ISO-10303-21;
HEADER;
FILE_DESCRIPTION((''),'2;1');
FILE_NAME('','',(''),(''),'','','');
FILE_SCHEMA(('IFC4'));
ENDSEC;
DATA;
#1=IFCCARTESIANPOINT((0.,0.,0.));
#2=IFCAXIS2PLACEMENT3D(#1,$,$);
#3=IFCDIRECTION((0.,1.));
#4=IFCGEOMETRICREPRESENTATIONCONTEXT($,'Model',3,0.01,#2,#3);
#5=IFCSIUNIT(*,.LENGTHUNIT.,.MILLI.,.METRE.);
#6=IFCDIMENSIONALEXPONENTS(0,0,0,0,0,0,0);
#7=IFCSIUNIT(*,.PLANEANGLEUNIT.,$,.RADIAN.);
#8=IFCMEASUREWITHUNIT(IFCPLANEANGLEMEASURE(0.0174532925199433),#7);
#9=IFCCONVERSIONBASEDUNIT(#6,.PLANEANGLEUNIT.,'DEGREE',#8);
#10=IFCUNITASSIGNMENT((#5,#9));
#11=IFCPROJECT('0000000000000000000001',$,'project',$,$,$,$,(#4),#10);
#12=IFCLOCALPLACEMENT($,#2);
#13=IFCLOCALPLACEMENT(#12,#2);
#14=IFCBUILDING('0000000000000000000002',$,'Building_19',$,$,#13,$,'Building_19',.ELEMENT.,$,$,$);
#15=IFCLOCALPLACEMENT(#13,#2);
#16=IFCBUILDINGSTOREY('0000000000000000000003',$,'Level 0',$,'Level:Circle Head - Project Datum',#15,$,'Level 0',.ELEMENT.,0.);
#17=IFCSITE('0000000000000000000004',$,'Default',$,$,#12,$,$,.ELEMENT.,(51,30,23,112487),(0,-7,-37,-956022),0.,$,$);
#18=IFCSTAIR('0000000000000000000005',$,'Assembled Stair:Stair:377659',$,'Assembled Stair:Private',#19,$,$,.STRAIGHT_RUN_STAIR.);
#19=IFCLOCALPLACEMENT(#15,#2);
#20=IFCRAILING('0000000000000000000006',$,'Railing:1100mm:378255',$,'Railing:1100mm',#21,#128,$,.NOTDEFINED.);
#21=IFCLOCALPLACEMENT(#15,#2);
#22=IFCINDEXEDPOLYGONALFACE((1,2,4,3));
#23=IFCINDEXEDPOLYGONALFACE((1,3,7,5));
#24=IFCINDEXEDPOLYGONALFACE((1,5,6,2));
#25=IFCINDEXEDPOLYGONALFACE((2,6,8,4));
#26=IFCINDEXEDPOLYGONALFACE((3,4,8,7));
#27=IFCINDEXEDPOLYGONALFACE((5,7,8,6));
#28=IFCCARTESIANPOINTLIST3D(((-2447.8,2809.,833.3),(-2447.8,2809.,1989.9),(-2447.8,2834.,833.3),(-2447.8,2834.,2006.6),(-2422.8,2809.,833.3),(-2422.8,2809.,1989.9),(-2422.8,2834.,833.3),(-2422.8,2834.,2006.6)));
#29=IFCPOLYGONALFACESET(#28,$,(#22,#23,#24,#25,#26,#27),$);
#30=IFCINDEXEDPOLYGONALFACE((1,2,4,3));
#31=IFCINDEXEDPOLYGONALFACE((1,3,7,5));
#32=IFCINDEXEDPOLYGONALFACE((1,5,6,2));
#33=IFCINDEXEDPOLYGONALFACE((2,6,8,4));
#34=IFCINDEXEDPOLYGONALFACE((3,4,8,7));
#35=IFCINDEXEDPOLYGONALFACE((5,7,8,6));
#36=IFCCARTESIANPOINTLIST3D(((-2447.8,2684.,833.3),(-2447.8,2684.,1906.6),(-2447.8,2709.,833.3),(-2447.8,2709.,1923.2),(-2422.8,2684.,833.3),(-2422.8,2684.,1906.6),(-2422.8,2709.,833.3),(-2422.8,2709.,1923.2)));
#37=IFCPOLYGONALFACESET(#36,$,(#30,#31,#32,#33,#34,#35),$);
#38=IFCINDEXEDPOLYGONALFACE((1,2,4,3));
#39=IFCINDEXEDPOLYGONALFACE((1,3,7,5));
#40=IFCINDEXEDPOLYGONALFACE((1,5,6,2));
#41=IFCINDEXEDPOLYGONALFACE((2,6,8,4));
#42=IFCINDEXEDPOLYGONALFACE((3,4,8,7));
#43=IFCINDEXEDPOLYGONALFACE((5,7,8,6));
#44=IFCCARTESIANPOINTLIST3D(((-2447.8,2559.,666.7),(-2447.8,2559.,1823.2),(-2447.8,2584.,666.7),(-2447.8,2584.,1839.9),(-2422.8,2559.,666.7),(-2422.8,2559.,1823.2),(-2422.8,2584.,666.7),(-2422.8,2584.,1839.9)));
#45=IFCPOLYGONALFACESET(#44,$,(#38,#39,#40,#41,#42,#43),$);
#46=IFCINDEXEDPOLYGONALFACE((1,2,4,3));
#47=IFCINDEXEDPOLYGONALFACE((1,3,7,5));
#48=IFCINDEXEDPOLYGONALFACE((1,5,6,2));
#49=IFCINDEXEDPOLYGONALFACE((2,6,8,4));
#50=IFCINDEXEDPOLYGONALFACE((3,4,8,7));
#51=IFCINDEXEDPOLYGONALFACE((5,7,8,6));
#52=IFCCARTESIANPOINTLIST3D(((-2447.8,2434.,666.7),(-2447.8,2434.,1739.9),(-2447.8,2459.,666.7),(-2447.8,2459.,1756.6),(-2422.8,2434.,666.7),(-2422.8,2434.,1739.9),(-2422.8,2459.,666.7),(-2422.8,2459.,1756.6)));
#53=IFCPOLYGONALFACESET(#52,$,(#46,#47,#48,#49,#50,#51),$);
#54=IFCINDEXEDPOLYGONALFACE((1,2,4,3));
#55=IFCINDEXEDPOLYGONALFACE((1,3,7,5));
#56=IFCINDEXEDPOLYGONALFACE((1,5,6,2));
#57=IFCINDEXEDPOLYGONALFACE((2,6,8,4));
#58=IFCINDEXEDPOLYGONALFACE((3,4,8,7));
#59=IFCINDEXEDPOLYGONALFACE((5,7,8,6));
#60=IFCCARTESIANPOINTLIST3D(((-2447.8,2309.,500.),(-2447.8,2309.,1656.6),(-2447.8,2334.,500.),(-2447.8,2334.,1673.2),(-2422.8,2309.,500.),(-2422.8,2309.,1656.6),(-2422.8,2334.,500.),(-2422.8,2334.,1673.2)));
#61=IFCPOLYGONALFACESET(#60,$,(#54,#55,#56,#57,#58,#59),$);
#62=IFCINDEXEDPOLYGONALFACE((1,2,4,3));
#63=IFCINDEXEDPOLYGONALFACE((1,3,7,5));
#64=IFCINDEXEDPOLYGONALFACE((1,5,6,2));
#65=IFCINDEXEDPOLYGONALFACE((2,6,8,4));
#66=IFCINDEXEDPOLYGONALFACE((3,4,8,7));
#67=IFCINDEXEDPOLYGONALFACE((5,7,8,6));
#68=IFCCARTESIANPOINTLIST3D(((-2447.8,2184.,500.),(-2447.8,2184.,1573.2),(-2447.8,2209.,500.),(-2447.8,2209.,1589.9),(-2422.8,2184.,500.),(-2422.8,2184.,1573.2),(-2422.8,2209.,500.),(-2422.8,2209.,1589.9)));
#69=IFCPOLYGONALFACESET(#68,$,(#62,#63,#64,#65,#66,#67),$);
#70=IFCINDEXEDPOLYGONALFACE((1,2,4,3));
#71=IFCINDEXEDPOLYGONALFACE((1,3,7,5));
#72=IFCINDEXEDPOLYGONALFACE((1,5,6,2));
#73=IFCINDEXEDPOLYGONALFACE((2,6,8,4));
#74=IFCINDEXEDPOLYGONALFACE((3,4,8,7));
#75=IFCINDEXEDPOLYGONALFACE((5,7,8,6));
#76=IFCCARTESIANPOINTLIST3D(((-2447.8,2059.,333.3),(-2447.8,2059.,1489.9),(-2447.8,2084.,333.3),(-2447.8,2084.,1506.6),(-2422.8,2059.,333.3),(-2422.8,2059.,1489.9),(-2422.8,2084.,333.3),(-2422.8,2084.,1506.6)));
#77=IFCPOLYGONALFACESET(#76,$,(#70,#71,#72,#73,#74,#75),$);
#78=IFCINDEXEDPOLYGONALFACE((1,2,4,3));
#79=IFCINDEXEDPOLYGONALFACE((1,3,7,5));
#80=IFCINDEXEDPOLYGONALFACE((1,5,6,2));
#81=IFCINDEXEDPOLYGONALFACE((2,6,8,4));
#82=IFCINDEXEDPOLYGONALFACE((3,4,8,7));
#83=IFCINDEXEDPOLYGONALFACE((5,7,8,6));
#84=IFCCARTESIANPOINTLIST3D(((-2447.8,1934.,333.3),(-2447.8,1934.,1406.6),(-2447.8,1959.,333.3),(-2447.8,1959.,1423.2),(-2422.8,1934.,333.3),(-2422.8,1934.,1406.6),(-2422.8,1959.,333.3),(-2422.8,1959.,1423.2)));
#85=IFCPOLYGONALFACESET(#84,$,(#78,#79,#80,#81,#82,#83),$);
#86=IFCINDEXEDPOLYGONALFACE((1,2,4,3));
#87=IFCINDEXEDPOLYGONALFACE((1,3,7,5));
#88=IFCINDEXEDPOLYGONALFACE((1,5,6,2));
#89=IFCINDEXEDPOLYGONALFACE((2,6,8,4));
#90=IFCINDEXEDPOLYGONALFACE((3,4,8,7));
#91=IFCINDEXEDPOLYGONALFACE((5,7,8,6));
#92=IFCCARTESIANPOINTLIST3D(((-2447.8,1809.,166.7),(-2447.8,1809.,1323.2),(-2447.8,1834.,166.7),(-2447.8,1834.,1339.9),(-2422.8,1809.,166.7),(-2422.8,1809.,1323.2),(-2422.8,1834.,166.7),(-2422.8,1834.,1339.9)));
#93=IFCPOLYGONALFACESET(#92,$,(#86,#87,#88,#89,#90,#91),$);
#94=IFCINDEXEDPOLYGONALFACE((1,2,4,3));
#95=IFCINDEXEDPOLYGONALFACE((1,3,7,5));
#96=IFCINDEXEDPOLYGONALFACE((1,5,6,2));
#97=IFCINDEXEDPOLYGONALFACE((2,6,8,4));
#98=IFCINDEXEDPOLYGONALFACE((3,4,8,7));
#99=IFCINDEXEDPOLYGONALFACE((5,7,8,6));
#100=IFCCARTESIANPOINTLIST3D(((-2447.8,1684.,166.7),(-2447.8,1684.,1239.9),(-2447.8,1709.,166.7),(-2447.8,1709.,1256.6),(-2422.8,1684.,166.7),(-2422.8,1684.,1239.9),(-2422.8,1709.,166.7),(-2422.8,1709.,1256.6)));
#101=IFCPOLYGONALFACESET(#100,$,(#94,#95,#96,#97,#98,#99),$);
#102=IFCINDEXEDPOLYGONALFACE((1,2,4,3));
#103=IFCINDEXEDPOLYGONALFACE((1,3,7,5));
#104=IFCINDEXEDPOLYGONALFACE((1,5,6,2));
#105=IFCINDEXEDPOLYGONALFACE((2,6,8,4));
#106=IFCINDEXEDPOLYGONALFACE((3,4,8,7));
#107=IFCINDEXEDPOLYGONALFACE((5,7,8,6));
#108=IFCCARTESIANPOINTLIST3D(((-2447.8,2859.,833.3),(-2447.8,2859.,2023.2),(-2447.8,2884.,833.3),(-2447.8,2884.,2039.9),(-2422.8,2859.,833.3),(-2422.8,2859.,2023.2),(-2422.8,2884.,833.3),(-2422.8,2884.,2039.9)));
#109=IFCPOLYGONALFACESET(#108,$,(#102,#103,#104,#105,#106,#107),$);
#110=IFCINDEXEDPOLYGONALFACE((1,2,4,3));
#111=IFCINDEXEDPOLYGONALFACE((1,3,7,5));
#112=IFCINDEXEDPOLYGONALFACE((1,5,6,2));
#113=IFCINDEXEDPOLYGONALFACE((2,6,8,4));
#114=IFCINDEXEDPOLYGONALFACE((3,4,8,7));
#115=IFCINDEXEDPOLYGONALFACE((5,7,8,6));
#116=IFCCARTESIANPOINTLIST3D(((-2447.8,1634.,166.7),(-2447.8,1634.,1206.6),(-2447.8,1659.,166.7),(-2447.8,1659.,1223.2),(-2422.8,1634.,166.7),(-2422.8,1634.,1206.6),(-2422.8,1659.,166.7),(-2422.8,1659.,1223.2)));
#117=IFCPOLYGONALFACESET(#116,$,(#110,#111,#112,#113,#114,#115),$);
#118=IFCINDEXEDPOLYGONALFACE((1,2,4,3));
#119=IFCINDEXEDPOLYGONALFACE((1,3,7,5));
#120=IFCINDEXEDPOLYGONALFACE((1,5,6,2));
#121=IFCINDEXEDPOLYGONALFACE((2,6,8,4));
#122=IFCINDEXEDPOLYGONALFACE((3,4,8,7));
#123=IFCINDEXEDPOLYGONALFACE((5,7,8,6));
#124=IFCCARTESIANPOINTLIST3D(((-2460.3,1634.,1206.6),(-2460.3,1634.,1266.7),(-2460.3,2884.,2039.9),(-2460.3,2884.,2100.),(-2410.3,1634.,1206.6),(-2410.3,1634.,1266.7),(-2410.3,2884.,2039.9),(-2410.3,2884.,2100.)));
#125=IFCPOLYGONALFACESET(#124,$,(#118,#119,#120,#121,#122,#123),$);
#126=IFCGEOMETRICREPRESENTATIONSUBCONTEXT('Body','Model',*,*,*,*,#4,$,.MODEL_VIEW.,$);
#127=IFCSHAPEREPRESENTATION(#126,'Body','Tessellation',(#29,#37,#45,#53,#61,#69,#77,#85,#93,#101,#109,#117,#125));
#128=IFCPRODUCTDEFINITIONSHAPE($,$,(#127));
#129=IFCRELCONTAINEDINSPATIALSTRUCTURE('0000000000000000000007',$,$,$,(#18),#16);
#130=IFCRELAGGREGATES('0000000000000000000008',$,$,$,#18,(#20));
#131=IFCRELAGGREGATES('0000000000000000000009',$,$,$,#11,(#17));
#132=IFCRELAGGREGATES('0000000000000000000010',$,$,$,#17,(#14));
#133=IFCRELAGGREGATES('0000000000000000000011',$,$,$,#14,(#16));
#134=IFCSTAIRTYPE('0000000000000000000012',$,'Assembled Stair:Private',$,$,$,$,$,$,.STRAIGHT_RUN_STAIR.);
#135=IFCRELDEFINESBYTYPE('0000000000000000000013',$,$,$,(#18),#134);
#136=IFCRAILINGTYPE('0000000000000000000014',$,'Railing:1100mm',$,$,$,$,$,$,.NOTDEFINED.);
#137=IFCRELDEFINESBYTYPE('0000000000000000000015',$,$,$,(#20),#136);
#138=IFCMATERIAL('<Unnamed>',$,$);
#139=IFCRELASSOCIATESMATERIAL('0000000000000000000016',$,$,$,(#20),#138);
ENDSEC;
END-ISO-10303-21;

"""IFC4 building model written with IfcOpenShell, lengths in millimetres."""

from ifc_helpers import new_model, entity, si_unit, converted_unit, direction, frame, origin, place, context, subcontext, project, spatial, indexed_curve, outline, extrude, material, type_object, element, aggregate, save


model = new_model("IFC4")

# Units and contexts
model_context = context("Model", 3, precision=0.01, world=origin(), true_north=direction((0.0, 1.0)))
body_context = subcontext(model_context, "Body", "Model", "MODEL_VIEW")
ifc_project = project(units=[si_unit("LENGTHUNIT", "METRE", prefix="MILLI"), converted_unit("PLANEANGLEUNIT", "DEGREE", entity("IfcPlaneAngleMeasure", 0.0174532925199433), si_unit("PLANEANGLEUNIT", "RADIAN"), dimensions=[0, 0, 0, 0, 0, 0, 0])], contexts=[model_context])

# Site, building, storey
site_placement = place(None, origin())
site = spatial("IfcSite", under=ifc_project, at=site_placement, Name="Default", CompositionType="ELEMENT", RefLatitude=(51, 30, 23, 112487), RefLongitude=(0, -7, -37, -956022), RefElevation=0.0)
building_placement = place(site_placement, origin())
building = spatial("IfcBuilding", under=site, at=building_placement, Name="Building_19", LongName="Building_19", CompositionType="ELEMENT")
storey_placement = place(building_placement, origin())
storey = spatial("IfcBuildingStorey", under=building, at=storey_placement, Name="Level 0", ObjectType="Level:Circle Head - Project Datum", LongName="Level 0", CompositionType="ELEMENT", Elevation=0.0)

# Stair, railing
stair_type = type_object("IfcStairType", Name="Assembled Stair:Private", PredefinedType="STRAIGHT_RUN_STAIR")
stair_1_placement = place(storey_placement, origin())
stair_1 = element("IfcStair", 1, at=stair_1_placement, inside=storey, type_object=stair_type, Name="Assembled Stair:Stair:377659", ObjectType="Assembled Stair:Private", PredefinedType="STRAIGHT_RUN_STAIR")
ifc_material_1 = material(Name="<Unnamed>")
railing_type = type_object("IfcRailingType", Name="Railing:1100mm", PredefinedType="NOTDEFINED")
railing_1_placement = place(stair_1_placement, origin())
railing_1 = element("IfcRailing", 2, at=railing_1_placement, type_object=railing_type, material=ifc_material_1, Name="Railing:1100mm:378255", ObjectType="Railing:1100mm", PredefinedType="NOTDEFINED", context=body_context, shape_type="SweptSolid", body=[
    extrude(outline(indexed_curve([(-12.5, -582.5), (12.5, -582.5), (12.5, 590.8), (-12.5, 574.1), (-12.5, -582.5)], self_intersect=False)), frame((-2447.8, 2821.5, 1415.8), z_axis=(1.0, 0.0, 0.0), x_axis=(0.0, 1.0, 0.0)), (0.0, 0.0, 1.0), 25.0),
    extrude(outline(indexed_curve([(-12.5, -540.8), (12.5, -540.8), (12.5, 549.1), (-12.5, 532.5), (-12.5, -540.8)], self_intersect=False)), frame((-2447.8, 2696.5, 1374.1), z_axis=(1.0, 0.0, 0.0), x_axis=(0.0, 1.0, 0.0)), (0.0, 0.0, 1.0), 25.0),
    extrude(outline(indexed_curve([(-12.5, -582.5), (12.5, -582.5), (12.5, 590.8), (-12.5, 574.1), (-12.5, -582.5)], self_intersect=False)), frame((-2447.8, 2571.5, 1249.1), z_axis=(1.0, 0.0, 0.0), x_axis=(0.0, 1.0, 0.0)), (0.0, 0.0, 1.0), 25.0),
    extrude(outline(indexed_curve([(-12.5, -540.8), (12.5, -540.8), (12.5, 549.1), (-12.5, 532.5), (-12.5, -540.8)], self_intersect=False)), frame((-2447.8, 2446.5, 1207.5), z_axis=(1.0, 0.0, 0.0), x_axis=(0.0, 1.0, 0.0)), (0.0, 0.0, 1.0), 25.0),
    extrude(outline(indexed_curve([(-12.5, -582.5), (12.5, -582.5), (12.5, 590.8), (-12.5, 574.1), (-12.5, -582.5)], self_intersect=False)), frame((-2447.8, 2321.5, 1082.5), z_axis=(1.0, 0.0, 0.0), x_axis=(0.0, 1.0, 0.0)), (0.0, 0.0, 1.0), 25.0),
    extrude(outline(indexed_curve([(-12.5, -540.8), (12.5, -540.8), (12.5, 549.1), (-12.5, 532.5), (-12.5, -540.8)], self_intersect=False)), frame((-2447.8, 2196.5, 1040.8), z_axis=(1.0, 0.0, 0.0), x_axis=(0.0, 1.0, 0.0)), (0.0, 0.0, 1.0), 25.0),
    extrude(outline(indexed_curve([(-12.5, -582.5), (12.5, -582.5), (12.5, 590.8), (-12.5, 574.1), (-12.5, -582.5)], self_intersect=False)), frame((-2447.8, 2071.5, 915.8), z_axis=(1.0, 0.0, 0.0), x_axis=(0.0, 1.0, 0.0)), (0.0, 0.0, 1.0), 25.0),
    extrude(outline(indexed_curve([(-12.5, -540.8), (12.5, -540.8), (12.5, 549.1), (-12.5, 532.5), (-12.5, -540.8)], self_intersect=False)), frame((-2447.8, 1946.5, 874.1), z_axis=(1.0, 0.0, 0.0), x_axis=(0.0, 1.0, 0.0)), (0.0, 0.0, 1.0), 25.0),
    extrude(outline(indexed_curve([(-12.5, -582.5), (12.5, -582.5), (12.5, 590.8), (-12.5, 574.1), (-12.5, -582.5)], self_intersect=False)), frame((-2447.8, 1821.5, 749.1), z_axis=(1.0, 0.0, 0.0), x_axis=(0.0, 1.0, 0.0)), (0.0, 0.0, 1.0), 25.0),
    extrude(outline(indexed_curve([(-12.5, -540.8), (12.5, -540.8), (12.5, 549.1), (-12.5, 532.5), (-12.5, -540.8)], self_intersect=False)), frame((-2447.8, 1696.5, 707.5), z_axis=(1.0, 0.0, 0.0), x_axis=(0.0, 1.0, 0.0)), (0.0, 0.0, 1.0), 25.0),
    extrude(outline(indexed_curve([(-12.5, -599.1), (12.5, -599.1), (12.5, 607.5), (-12.5, 590.8), (-12.5, -599.1)], self_intersect=False)), frame((-2447.8, 2871.5, 1432.5), z_axis=(1.0, 0.0, 0.0), x_axis=(0.0, 1.0, 0.0)), (0.0, 0.0, 1.0), 25.0),
    extrude(outline(indexed_curve([(-12.5, -524.1), (12.5, -524.1), (12.5, 532.5), (-12.5, 515.8), (-12.5, -524.1)], self_intersect=False)), frame((-2447.8, 1646.5, 690.8), z_axis=(1.0, 0.0, 0.0), x_axis=(0.0, 1.0, 0.0)), (0.0, 0.0, 1.0), 25.0),
    extrude(outline(indexed_curve([(-767.8, -25.0), (734.5, -25.0), (767.8, 25.0), (-734.5, 25.0), (-767.8, -25.0)], self_intersect=False)), frame((-2460.3, 2259.0, 1653.3), z_axis=(1.0, 0.0, 0.0), x_axis=(0.0, 0.83205, 0.5547)), (0.0, 0.0, 1.0), 50.0),
])
aggregate(stair_1, [railing_1])

save(model, "model.ifc")
